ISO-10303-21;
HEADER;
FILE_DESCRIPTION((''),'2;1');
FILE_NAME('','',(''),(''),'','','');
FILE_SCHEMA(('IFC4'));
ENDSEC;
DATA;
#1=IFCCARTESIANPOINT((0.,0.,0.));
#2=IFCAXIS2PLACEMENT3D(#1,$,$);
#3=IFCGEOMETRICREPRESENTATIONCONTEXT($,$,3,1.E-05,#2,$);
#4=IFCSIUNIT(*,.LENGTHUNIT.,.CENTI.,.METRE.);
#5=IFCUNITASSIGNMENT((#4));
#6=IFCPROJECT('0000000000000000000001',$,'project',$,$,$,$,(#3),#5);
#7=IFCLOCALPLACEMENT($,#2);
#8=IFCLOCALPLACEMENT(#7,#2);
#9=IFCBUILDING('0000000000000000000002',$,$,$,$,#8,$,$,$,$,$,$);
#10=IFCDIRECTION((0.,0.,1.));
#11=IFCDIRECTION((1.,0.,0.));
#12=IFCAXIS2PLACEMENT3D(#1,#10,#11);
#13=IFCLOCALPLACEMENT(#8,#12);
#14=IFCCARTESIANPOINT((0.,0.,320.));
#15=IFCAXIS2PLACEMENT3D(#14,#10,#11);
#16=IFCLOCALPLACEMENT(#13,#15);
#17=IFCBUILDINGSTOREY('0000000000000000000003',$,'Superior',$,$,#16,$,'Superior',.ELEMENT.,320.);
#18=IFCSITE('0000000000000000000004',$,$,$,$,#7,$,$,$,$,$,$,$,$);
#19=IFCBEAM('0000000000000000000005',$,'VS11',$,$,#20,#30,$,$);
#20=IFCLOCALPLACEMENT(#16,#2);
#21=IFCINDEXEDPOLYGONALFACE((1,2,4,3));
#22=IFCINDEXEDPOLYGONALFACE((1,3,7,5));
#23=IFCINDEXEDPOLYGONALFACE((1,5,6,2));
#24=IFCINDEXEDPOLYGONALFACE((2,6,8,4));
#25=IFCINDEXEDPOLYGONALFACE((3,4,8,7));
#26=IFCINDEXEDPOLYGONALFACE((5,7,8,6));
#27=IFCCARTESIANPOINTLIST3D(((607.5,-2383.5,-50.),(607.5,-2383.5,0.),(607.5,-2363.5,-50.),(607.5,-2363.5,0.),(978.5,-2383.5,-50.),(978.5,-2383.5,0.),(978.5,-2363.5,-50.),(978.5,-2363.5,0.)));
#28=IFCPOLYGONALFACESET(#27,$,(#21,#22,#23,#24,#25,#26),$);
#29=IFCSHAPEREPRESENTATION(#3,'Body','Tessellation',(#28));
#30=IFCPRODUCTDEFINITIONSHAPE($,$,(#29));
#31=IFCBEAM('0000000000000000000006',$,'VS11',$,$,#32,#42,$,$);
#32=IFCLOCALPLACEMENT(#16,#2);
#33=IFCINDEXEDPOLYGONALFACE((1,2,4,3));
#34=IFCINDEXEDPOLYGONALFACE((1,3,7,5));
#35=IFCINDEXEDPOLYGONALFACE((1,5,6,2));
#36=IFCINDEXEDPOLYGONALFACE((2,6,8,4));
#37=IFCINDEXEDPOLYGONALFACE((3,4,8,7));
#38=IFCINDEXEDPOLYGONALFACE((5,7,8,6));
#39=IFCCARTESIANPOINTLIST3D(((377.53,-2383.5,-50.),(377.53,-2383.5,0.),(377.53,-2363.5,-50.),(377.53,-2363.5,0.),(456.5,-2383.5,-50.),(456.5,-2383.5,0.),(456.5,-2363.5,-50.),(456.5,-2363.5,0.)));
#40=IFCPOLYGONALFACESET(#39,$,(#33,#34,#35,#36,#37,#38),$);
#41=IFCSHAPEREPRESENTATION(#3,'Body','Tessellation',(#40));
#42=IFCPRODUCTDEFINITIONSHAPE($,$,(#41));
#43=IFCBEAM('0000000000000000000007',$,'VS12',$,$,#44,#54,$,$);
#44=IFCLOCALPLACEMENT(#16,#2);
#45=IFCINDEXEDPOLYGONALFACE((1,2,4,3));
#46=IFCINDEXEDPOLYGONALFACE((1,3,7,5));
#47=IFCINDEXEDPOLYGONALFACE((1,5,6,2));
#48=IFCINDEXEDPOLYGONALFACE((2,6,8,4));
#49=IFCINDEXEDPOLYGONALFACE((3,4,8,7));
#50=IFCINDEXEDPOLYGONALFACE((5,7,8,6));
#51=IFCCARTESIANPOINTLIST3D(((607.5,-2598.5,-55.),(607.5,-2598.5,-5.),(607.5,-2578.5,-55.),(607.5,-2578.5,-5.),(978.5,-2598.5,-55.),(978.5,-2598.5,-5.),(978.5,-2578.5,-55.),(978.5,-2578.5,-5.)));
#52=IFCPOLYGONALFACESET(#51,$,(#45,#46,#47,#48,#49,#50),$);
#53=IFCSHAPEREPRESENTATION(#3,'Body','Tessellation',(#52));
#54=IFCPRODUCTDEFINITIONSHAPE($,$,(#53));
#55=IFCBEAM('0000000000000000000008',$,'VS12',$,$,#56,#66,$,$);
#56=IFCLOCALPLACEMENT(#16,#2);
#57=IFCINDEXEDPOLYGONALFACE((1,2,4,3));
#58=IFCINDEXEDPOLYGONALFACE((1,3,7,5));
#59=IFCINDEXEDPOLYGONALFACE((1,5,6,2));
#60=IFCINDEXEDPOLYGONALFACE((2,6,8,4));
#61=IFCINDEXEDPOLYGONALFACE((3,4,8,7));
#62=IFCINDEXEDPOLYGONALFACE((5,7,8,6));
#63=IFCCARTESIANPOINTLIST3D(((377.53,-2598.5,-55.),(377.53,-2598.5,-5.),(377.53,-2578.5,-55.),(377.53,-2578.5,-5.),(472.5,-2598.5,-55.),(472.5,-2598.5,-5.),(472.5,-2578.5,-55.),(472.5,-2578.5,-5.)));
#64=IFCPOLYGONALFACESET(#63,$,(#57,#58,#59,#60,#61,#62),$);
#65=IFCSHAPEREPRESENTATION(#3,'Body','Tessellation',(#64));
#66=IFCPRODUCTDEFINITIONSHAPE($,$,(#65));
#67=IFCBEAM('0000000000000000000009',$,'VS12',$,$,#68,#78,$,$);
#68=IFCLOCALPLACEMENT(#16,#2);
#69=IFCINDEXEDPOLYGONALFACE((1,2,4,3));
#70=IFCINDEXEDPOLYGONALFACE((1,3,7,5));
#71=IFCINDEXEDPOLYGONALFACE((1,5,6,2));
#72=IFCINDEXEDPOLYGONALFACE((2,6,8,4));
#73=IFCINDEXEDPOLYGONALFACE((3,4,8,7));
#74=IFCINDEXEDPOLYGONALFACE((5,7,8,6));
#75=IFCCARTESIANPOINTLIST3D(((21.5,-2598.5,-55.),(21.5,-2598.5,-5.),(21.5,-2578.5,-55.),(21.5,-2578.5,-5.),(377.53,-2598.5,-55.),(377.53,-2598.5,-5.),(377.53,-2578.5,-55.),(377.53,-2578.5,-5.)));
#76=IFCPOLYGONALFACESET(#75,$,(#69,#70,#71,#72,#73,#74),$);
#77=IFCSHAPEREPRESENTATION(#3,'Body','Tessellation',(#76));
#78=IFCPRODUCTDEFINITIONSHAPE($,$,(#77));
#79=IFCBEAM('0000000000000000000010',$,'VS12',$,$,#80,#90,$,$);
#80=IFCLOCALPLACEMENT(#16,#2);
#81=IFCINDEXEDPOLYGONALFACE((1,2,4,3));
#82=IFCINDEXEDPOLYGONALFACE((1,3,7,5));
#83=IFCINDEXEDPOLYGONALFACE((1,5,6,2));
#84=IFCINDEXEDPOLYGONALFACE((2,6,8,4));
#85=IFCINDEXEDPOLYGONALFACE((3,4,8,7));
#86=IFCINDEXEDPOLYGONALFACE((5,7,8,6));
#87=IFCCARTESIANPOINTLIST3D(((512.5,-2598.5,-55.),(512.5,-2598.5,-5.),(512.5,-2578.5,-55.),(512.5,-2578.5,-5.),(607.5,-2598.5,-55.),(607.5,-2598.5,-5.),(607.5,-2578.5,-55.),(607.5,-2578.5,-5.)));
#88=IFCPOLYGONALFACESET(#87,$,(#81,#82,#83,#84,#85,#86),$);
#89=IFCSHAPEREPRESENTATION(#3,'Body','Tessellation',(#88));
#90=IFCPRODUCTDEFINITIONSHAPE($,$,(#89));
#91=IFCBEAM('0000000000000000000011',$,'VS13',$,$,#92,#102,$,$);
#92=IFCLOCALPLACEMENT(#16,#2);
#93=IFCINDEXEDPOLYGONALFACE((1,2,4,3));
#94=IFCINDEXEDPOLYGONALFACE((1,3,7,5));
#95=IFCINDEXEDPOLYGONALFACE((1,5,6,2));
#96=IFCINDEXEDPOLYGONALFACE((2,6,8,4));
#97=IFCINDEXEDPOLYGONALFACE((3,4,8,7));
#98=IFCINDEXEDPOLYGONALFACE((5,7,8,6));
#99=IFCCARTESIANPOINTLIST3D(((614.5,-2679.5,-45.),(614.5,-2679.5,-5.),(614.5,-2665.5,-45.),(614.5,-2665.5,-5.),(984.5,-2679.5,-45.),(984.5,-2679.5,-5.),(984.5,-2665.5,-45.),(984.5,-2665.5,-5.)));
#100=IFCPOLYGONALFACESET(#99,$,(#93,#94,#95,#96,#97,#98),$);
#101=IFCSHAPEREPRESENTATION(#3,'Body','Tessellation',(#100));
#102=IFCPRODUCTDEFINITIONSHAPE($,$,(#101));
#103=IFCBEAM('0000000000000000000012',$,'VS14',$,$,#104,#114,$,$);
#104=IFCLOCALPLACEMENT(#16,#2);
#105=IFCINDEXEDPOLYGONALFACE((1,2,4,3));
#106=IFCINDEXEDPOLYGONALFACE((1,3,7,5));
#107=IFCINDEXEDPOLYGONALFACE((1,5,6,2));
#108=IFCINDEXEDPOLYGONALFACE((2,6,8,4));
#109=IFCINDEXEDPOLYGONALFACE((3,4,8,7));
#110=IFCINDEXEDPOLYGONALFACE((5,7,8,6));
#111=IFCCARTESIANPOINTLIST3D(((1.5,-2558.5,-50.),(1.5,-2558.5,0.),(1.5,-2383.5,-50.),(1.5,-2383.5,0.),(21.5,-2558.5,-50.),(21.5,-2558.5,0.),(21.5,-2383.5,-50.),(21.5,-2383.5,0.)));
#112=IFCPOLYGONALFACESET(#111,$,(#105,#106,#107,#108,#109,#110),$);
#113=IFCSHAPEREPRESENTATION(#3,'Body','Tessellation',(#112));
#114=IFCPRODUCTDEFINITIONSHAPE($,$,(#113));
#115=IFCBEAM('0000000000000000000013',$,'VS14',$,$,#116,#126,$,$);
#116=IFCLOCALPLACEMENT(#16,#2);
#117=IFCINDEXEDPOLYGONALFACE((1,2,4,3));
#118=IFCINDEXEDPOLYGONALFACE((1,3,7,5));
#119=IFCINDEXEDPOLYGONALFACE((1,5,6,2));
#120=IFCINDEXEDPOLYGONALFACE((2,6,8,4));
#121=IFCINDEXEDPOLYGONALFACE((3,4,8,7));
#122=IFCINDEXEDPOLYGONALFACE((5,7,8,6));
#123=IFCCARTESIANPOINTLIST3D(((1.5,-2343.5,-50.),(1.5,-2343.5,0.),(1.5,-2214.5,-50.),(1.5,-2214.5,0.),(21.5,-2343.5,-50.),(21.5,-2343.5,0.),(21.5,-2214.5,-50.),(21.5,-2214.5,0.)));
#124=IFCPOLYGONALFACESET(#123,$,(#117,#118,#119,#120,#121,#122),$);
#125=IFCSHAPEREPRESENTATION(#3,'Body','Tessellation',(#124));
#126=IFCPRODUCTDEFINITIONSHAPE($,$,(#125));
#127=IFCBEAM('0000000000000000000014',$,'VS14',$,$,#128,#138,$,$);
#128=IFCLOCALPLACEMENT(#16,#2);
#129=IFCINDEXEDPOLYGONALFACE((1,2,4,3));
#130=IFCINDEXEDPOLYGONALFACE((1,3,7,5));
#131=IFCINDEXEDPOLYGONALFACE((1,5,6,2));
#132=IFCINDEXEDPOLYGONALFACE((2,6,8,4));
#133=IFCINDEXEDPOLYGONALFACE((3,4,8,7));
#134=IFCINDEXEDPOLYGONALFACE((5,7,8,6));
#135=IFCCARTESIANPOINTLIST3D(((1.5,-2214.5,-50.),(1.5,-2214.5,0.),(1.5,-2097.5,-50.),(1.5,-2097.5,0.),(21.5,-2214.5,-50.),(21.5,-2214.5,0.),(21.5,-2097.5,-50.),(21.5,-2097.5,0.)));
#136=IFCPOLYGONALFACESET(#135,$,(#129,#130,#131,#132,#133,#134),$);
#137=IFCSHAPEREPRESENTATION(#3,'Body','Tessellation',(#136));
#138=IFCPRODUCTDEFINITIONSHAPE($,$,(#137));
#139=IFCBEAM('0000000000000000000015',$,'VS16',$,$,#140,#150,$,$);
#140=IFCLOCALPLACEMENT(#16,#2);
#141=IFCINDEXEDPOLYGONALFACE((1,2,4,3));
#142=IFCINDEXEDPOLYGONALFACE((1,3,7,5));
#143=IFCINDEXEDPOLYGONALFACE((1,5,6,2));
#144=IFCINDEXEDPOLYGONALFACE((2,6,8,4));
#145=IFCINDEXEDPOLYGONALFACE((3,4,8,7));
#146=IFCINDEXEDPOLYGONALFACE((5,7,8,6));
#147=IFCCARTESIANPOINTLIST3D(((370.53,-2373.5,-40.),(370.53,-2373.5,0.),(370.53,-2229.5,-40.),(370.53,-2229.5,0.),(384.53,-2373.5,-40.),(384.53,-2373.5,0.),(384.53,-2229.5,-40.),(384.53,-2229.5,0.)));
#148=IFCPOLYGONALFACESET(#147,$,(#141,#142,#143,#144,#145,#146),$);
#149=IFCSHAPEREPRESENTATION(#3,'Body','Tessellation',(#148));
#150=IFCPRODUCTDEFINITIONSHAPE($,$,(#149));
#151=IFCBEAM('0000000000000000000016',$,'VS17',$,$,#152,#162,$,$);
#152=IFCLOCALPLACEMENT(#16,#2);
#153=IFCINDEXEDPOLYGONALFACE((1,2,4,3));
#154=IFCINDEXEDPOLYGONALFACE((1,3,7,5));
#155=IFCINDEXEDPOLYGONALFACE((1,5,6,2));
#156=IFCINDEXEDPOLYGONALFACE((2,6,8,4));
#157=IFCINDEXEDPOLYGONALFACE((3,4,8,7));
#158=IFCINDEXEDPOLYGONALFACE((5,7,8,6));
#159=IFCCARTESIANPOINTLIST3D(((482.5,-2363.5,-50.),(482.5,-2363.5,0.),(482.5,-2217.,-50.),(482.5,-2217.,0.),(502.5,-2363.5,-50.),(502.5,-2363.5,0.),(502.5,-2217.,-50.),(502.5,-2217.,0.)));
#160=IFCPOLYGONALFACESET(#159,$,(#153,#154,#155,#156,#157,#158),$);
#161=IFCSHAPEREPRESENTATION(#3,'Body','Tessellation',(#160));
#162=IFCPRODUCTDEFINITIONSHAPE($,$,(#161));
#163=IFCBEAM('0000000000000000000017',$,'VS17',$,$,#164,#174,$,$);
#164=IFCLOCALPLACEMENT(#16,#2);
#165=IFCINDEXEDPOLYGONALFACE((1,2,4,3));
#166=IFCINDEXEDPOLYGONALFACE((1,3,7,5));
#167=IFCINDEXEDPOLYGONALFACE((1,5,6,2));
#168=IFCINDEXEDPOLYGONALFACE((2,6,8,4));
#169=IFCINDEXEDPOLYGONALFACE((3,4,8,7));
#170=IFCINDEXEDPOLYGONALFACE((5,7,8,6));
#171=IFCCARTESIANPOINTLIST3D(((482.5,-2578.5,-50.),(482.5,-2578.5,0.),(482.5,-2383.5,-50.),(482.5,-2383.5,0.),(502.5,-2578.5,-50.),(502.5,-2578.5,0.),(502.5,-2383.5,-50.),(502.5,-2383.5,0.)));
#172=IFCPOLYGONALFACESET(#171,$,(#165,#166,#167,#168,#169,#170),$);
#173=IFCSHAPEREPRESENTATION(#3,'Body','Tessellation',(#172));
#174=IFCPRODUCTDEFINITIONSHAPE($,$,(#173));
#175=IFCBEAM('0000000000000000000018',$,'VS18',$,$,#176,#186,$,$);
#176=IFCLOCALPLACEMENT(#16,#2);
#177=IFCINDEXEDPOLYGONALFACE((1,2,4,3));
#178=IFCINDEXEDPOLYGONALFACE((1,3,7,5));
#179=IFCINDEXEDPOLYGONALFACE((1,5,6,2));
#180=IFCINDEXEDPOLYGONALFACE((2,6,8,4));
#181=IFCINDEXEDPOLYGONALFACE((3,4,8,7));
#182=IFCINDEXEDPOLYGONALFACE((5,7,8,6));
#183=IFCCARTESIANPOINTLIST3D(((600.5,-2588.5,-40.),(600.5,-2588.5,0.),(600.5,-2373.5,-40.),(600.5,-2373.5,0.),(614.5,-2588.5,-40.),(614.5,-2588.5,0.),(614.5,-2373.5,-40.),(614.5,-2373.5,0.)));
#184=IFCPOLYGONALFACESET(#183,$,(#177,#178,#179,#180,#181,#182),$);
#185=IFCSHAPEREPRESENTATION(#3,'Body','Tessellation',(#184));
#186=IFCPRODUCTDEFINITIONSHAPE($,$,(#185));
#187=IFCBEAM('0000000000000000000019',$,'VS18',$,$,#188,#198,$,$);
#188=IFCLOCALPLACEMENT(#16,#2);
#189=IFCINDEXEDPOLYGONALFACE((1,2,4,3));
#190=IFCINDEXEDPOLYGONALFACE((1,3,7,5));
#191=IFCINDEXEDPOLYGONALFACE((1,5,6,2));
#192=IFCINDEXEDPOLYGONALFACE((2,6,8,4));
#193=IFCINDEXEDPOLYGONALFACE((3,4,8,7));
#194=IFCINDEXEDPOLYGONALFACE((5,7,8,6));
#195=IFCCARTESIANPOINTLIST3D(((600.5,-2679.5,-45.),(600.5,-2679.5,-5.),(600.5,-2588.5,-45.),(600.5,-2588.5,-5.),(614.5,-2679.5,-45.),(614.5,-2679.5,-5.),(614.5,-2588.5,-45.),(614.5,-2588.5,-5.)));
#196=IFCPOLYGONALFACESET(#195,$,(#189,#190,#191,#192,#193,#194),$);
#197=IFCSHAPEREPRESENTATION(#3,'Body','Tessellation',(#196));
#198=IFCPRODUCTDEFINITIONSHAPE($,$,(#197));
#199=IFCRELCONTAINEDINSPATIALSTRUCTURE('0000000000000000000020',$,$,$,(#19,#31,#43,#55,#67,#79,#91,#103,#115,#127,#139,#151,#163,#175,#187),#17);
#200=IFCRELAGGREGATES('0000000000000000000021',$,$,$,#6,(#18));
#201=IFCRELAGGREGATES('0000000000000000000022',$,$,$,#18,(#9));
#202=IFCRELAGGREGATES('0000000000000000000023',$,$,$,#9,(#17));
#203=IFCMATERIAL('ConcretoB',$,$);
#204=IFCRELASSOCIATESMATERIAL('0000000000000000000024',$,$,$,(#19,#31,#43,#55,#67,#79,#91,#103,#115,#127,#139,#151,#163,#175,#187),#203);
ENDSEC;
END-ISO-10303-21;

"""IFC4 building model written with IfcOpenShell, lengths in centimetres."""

from ifc_helpers import new_model, si_unit, frame, origin, origin_with_axes, place, context, project, spatial, polyline, outline, extrude, material, element, save


model = new_model("IFC4")

# Units and contexts
context_of_model = context(None, 3, precision=1e-05, world=origin())
ifc_project = project(units=[si_unit("LENGTHUNIT", "METRE", prefix="CENTI")], contexts=[context_of_model])

# Site, building, storey
site_placement = place(None, origin())
site = spatial("IfcSite", under=ifc_project, at=site_placement)
building_placement = place(site_placement, origin())
building = spatial("IfcBuilding", under=site, at=building_placement)
placement = place(building_placement, origin_with_axes())
storey_placement = place(placement, frame((0.0, 0.0, 320.0), z_axis=(0.0, 0.0, 1.0), x_axis=(1.0, 0.0, 0.0)))
storey = spatial("IfcBuildingStorey", under=building, at=storey_placement, Name="Superior", LongName="Superior", CompositionType="ELEMENT", Elevation=320.0)

# Shared definitions
ifc_material = material(Name="ConcretoB")

# Beams
beam_1_placement = place(storey_placement, frame((793.0, -2373.5, 0.0), z_axis=(0.0, 0.0, 1.0), x_axis=(1.0, 0.0, 0.0)))
element("IfcBeam", 1, at=beam_1_placement, inside=storey, material=ifc_material, Name="VS11", context=context_of_model, shape_type="SolidModel", body=[
    extrude(outline(polyline([(-10.0, -25.0), (10.0, -25.0), (10.0, 25.0), (-10.0, 25.0), (-10.0, -25.0)])), frame((-185.5, 0.0, -25.0), z_axis=(1.0, 0.0, 0.0), x_axis=(0.0, -1.0, 0.0)), (0.0, 0.0, 1.0), 371.0),
])
beam_2_placement = place(storey_placement, frame((417.01, -2373.5, 0.0), z_axis=(0.0, 0.0, 1.0), x_axis=(1.0, 0.0, 0.0)))
element("IfcBeam", 2, at=beam_2_placement, inside=storey, material=ifc_material, Name="VS11", context=context_of_model, shape_type="SolidModel", body=[
    extrude(outline(polyline([(-10.0, -25.0), (10.0, -25.0), (10.0, 25.0), (-10.0, 25.0), (-10.0, -25.0)])), frame((-39.48, 0.0, -25.0), z_axis=(1.0, 0.0, 0.0), x_axis=(0.0, -1.0, 0.0)), (0.0, 0.0, 1.0), 78.97),
])
beam_3_placement = place(storey_placement, frame((793.0, -2588.5, -5.0), z_axis=(0.0, 0.0, 1.0), x_axis=(1.0, 0.0, 0.0)))
element("IfcBeam", 3, at=beam_3_placement, inside=storey, material=ifc_material, Name="VS12", context=context_of_model, shape_type="SolidModel", body=[
    extrude(outline(polyline([(-10.0, -25.0), (10.0, -25.0), (10.0, 25.0), (-10.0, 25.0), (-10.0, -25.0)])), frame((-185.5, 0.0, -25.0), z_axis=(1.0, 0.0, 0.0), x_axis=(0.0, -1.0, 0.0)), (0.0, 0.0, 1.0), 371.0),
])
beam_4_placement = place(storey_placement, frame((425.01, -2588.5, -5.0), z_axis=(0.0, 0.0, 1.0), x_axis=(1.0, 0.0, 0.0)))
element("IfcBeam", 4, at=beam_4_placement, inside=storey, material=ifc_material, Name="VS12", context=context_of_model, shape_type="SolidModel", body=[
    extrude(outline(polyline([(-10.0, -25.0), (10.0, -25.0), (10.0, 25.0), (-10.0, 25.0), (-10.0, -25.0)])), frame((-47.48, 0.0, -25.0), z_axis=(1.0, 0.0, 0.0), x_axis=(0.0, -1.0, 0.0)), (0.0, 0.0, 1.0), 94.97),
])
beam_5_placement = place(storey_placement, frame((199.51, -2588.5, -5.0), z_axis=(0.0, 0.0, 1.0), x_axis=(1.0, 0.0, 0.0)))
element("IfcBeam", 5, at=beam_5_placement, inside=storey, material=ifc_material, Name="VS12", context=context_of_model, shape_type="SolidModel", body=[
    extrude(outline(polyline([(-10.0, -25.0), (10.0, -25.0), (10.0, 25.0), (-10.0, 25.0), (-10.0, -25.0)])), frame((-178.01, 0.0, -25.0), z_axis=(1.0, 0.0, 0.0), x_axis=(0.0, -1.0, 0.0)), (0.0, 0.0, 1.0), 356.03),
])
beam_6_placement = place(storey_placement, frame((560.0, -2588.5, -5.0), z_axis=(0.0, 0.0, 1.0), x_axis=(1.0, 0.0, 0.0)))
element("IfcBeam", 6, at=beam_6_placement, inside=storey, material=ifc_material, Name="VS12", context=context_of_model, shape_type="SolidModel", body=[
    extrude(outline(polyline([(-10.0, -25.0), (10.0, -25.0), (10.0, 25.0), (-10.0, 25.0), (-10.0, -25.0)])), frame((-47.5, 0.0, -25.0), z_axis=(1.0, 0.0, 0.0), x_axis=(0.0, -1.0, 0.0)), (0.0, 0.0, 1.0), 95.0),
])
beam_7_placement = place(storey_placement, frame((799.5, -2672.5, -5.0), z_axis=(0.0, 0.0, 1.0), x_axis=(1.0, 0.0, 0.0)))
element("IfcBeam", 7, at=beam_7_placement, inside=storey, material=ifc_material, Name="VS13", context=context_of_model, shape_type="SolidModel", body=[
    extrude(outline(polyline([(-7.0, -20.0), (7.0, -20.0), (7.0, 20.0), (-7.0, 20.0), (-7.0, -20.0)])), frame((-185.0, 0.0, -20.0), z_axis=(1.0, 0.0, 0.0), x_axis=(0.0, -1.0, 0.0)), (0.0, 0.0, 1.0), 370.0),
])
beam_8_placement = place(storey_placement, frame((11.5, -2471.0, 0.0), z_axis=(0.0, 0.0, 1.0), x_axis=(1.0, 0.0, 0.0)))
element("IfcBeam", 8, at=beam_8_placement, inside=storey, material=ifc_material, Name="VS14", context=context_of_model, shape_type="SolidModel", body=[
    extrude(outline(polyline([(-10.0, -25.0), (10.0, -25.0), (10.0, 25.0), (-10.0, 25.0), (-10.0, -25.0)])), frame((0.0, -87.5, -25.0), z_axis=(0.0, 1.0, 0.0), x_axis=(1.0, 0.0, 0.0)), (0.0, 0.0, 1.0), 175.0),
])
beam_9_placement = place(storey_placement, frame((11.5, -2279.0, 0.0), z_axis=(0.0, 0.0, 1.0), x_axis=(1.0, 0.0, 0.0)))
element("IfcBeam", 9, at=beam_9_placement, inside=storey, material=ifc_material, Name="VS14", context=context_of_model, shape_type="SolidModel", body=[
    extrude(outline(polyline([(-10.0, -25.0), (10.0, -25.0), (10.0, 25.0), (-10.0, 25.0), (-10.0, -25.0)])), frame((0.0, -64.5, -25.0), z_axis=(0.0, 1.0, 0.0), x_axis=(1.0, 0.0, 0.0)), (0.0, 0.0, 1.0), 129.0),
])
beam_10_placement = place(storey_placement, frame((11.5, -2156.0, 0.0), z_axis=(0.0, 0.0, 1.0), x_axis=(1.0, 0.0, 0.0)))
element("IfcBeam", 10, at=beam_10_placement, inside=storey, material=ifc_material, Name="VS14", context=context_of_model, shape_type="SolidModel", body=[
    extrude(outline(polyline([(-10.0, -25.0), (10.0, -25.0), (10.0, 25.0), (-10.0, 25.0), (-10.0, -25.0)])), frame((0.0, -58.5, -25.0), z_axis=(0.0, 1.0, 0.0), x_axis=(1.0, 0.0, 0.0)), (0.0, 0.0, 1.0), 117.0),
])
beam_11_placement = place(storey_placement, frame((377.53, -2301.5, 0.0), z_axis=(0.0, 0.0, 1.0), x_axis=(1.0, 0.0, 0.0)))
element("IfcBeam", 11, at=beam_11_placement, inside=storey, material=ifc_material, Name="VS16", context=context_of_model, shape_type="SolidModel", body=[
    extrude(outline(polyline([(-7.0, -20.0), (7.0, -20.0), (7.0, 20.0), (-7.0, 20.0), (-7.0, -20.0)])), frame((0.0, -72.0, -20.0), z_axis=(0.0, 1.0, 0.0), x_axis=(1.0, 0.0, 0.0)), (0.0, 0.0, 1.0), 144.0),
])
beam_12_placement = place(storey_placement, frame((492.5, -2290.25, 0.0), z_axis=(0.0, 0.0, 1.0), x_axis=(1.0, 0.0, 0.0)))
element("IfcBeam", 12, at=beam_12_placement, inside=storey, material=ifc_material, Name="VS17", context=context_of_model, shape_type="SolidModel", body=[
    extrude(outline(polyline([(-10.0, -25.0), (10.0, -25.0), (10.0, 25.0), (-10.0, 25.0), (-10.0, -25.0)])), frame((0.0, -73.25, -25.0), z_axis=(0.0, 1.0, 0.0), x_axis=(1.0, 0.0, 0.0)), (0.0, 0.0, 1.0), 146.5),
])
beam_13_placement = place(storey_placement, frame((492.5, -2481.0, 0.0), z_axis=(0.0, 0.0, 1.0), x_axis=(1.0, 0.0, 0.0)))
element("IfcBeam", 13, at=beam_13_placement, inside=storey, material=ifc_material, Name="VS17", context=context_of_model, shape_type="SolidModel", body=[
    extrude(outline(polyline([(-10.0, -25.0), (10.0, -25.0), (10.0, 25.0), (-10.0, 25.0), (-10.0, -25.0)])), frame((0.0, -97.5, -25.0), z_axis=(0.0, 1.0, 0.0), x_axis=(1.0, 0.0, 0.0)), (0.0, 0.0, 1.0), 195.0),
])
beam_14_placement = place(storey_placement, frame((607.5, -2481.0, 0.0), z_axis=(0.0, 0.0, 1.0), x_axis=(1.0, 0.0, 0.0)))
element("IfcBeam", 14, at=beam_14_placement, inside=storey, material=ifc_material, Name="VS18", context=context_of_model, shape_type="SolidModel", body=[
    extrude(outline(polyline([(-7.0, -20.0), (7.0, -20.0), (7.0, 20.0), (-7.0, 20.0), (-7.0, -20.0)])), frame((0.0, -107.5, -20.0), z_axis=(0.0, 1.0, 0.0), x_axis=(1.0, 0.0, 0.0)), (0.0, 0.0, 1.0), 215.0),
])
beam_15_placement = place(storey_placement, frame((607.5, -2634.0, -5.0), z_axis=(0.0, 0.0, 1.0), x_axis=(1.0, 0.0, 0.0)))
element("IfcBeam", 15, at=beam_15_placement, inside=storey, material=ifc_material, Name="VS18", context=context_of_model, shape_type="SolidModel", body=[
    extrude(outline(polyline([(-7.0, -20.0), (7.0, -20.0), (7.0, 20.0), (-7.0, 20.0), (-7.0, -20.0)])), frame((0.0, -45.5, -20.0), z_axis=(0.0, 1.0, 0.0), x_axis=(1.0, 0.0, 0.0)), (0.0, 0.0, 1.0), 91.0),
])

save(model, "model.ifc")
